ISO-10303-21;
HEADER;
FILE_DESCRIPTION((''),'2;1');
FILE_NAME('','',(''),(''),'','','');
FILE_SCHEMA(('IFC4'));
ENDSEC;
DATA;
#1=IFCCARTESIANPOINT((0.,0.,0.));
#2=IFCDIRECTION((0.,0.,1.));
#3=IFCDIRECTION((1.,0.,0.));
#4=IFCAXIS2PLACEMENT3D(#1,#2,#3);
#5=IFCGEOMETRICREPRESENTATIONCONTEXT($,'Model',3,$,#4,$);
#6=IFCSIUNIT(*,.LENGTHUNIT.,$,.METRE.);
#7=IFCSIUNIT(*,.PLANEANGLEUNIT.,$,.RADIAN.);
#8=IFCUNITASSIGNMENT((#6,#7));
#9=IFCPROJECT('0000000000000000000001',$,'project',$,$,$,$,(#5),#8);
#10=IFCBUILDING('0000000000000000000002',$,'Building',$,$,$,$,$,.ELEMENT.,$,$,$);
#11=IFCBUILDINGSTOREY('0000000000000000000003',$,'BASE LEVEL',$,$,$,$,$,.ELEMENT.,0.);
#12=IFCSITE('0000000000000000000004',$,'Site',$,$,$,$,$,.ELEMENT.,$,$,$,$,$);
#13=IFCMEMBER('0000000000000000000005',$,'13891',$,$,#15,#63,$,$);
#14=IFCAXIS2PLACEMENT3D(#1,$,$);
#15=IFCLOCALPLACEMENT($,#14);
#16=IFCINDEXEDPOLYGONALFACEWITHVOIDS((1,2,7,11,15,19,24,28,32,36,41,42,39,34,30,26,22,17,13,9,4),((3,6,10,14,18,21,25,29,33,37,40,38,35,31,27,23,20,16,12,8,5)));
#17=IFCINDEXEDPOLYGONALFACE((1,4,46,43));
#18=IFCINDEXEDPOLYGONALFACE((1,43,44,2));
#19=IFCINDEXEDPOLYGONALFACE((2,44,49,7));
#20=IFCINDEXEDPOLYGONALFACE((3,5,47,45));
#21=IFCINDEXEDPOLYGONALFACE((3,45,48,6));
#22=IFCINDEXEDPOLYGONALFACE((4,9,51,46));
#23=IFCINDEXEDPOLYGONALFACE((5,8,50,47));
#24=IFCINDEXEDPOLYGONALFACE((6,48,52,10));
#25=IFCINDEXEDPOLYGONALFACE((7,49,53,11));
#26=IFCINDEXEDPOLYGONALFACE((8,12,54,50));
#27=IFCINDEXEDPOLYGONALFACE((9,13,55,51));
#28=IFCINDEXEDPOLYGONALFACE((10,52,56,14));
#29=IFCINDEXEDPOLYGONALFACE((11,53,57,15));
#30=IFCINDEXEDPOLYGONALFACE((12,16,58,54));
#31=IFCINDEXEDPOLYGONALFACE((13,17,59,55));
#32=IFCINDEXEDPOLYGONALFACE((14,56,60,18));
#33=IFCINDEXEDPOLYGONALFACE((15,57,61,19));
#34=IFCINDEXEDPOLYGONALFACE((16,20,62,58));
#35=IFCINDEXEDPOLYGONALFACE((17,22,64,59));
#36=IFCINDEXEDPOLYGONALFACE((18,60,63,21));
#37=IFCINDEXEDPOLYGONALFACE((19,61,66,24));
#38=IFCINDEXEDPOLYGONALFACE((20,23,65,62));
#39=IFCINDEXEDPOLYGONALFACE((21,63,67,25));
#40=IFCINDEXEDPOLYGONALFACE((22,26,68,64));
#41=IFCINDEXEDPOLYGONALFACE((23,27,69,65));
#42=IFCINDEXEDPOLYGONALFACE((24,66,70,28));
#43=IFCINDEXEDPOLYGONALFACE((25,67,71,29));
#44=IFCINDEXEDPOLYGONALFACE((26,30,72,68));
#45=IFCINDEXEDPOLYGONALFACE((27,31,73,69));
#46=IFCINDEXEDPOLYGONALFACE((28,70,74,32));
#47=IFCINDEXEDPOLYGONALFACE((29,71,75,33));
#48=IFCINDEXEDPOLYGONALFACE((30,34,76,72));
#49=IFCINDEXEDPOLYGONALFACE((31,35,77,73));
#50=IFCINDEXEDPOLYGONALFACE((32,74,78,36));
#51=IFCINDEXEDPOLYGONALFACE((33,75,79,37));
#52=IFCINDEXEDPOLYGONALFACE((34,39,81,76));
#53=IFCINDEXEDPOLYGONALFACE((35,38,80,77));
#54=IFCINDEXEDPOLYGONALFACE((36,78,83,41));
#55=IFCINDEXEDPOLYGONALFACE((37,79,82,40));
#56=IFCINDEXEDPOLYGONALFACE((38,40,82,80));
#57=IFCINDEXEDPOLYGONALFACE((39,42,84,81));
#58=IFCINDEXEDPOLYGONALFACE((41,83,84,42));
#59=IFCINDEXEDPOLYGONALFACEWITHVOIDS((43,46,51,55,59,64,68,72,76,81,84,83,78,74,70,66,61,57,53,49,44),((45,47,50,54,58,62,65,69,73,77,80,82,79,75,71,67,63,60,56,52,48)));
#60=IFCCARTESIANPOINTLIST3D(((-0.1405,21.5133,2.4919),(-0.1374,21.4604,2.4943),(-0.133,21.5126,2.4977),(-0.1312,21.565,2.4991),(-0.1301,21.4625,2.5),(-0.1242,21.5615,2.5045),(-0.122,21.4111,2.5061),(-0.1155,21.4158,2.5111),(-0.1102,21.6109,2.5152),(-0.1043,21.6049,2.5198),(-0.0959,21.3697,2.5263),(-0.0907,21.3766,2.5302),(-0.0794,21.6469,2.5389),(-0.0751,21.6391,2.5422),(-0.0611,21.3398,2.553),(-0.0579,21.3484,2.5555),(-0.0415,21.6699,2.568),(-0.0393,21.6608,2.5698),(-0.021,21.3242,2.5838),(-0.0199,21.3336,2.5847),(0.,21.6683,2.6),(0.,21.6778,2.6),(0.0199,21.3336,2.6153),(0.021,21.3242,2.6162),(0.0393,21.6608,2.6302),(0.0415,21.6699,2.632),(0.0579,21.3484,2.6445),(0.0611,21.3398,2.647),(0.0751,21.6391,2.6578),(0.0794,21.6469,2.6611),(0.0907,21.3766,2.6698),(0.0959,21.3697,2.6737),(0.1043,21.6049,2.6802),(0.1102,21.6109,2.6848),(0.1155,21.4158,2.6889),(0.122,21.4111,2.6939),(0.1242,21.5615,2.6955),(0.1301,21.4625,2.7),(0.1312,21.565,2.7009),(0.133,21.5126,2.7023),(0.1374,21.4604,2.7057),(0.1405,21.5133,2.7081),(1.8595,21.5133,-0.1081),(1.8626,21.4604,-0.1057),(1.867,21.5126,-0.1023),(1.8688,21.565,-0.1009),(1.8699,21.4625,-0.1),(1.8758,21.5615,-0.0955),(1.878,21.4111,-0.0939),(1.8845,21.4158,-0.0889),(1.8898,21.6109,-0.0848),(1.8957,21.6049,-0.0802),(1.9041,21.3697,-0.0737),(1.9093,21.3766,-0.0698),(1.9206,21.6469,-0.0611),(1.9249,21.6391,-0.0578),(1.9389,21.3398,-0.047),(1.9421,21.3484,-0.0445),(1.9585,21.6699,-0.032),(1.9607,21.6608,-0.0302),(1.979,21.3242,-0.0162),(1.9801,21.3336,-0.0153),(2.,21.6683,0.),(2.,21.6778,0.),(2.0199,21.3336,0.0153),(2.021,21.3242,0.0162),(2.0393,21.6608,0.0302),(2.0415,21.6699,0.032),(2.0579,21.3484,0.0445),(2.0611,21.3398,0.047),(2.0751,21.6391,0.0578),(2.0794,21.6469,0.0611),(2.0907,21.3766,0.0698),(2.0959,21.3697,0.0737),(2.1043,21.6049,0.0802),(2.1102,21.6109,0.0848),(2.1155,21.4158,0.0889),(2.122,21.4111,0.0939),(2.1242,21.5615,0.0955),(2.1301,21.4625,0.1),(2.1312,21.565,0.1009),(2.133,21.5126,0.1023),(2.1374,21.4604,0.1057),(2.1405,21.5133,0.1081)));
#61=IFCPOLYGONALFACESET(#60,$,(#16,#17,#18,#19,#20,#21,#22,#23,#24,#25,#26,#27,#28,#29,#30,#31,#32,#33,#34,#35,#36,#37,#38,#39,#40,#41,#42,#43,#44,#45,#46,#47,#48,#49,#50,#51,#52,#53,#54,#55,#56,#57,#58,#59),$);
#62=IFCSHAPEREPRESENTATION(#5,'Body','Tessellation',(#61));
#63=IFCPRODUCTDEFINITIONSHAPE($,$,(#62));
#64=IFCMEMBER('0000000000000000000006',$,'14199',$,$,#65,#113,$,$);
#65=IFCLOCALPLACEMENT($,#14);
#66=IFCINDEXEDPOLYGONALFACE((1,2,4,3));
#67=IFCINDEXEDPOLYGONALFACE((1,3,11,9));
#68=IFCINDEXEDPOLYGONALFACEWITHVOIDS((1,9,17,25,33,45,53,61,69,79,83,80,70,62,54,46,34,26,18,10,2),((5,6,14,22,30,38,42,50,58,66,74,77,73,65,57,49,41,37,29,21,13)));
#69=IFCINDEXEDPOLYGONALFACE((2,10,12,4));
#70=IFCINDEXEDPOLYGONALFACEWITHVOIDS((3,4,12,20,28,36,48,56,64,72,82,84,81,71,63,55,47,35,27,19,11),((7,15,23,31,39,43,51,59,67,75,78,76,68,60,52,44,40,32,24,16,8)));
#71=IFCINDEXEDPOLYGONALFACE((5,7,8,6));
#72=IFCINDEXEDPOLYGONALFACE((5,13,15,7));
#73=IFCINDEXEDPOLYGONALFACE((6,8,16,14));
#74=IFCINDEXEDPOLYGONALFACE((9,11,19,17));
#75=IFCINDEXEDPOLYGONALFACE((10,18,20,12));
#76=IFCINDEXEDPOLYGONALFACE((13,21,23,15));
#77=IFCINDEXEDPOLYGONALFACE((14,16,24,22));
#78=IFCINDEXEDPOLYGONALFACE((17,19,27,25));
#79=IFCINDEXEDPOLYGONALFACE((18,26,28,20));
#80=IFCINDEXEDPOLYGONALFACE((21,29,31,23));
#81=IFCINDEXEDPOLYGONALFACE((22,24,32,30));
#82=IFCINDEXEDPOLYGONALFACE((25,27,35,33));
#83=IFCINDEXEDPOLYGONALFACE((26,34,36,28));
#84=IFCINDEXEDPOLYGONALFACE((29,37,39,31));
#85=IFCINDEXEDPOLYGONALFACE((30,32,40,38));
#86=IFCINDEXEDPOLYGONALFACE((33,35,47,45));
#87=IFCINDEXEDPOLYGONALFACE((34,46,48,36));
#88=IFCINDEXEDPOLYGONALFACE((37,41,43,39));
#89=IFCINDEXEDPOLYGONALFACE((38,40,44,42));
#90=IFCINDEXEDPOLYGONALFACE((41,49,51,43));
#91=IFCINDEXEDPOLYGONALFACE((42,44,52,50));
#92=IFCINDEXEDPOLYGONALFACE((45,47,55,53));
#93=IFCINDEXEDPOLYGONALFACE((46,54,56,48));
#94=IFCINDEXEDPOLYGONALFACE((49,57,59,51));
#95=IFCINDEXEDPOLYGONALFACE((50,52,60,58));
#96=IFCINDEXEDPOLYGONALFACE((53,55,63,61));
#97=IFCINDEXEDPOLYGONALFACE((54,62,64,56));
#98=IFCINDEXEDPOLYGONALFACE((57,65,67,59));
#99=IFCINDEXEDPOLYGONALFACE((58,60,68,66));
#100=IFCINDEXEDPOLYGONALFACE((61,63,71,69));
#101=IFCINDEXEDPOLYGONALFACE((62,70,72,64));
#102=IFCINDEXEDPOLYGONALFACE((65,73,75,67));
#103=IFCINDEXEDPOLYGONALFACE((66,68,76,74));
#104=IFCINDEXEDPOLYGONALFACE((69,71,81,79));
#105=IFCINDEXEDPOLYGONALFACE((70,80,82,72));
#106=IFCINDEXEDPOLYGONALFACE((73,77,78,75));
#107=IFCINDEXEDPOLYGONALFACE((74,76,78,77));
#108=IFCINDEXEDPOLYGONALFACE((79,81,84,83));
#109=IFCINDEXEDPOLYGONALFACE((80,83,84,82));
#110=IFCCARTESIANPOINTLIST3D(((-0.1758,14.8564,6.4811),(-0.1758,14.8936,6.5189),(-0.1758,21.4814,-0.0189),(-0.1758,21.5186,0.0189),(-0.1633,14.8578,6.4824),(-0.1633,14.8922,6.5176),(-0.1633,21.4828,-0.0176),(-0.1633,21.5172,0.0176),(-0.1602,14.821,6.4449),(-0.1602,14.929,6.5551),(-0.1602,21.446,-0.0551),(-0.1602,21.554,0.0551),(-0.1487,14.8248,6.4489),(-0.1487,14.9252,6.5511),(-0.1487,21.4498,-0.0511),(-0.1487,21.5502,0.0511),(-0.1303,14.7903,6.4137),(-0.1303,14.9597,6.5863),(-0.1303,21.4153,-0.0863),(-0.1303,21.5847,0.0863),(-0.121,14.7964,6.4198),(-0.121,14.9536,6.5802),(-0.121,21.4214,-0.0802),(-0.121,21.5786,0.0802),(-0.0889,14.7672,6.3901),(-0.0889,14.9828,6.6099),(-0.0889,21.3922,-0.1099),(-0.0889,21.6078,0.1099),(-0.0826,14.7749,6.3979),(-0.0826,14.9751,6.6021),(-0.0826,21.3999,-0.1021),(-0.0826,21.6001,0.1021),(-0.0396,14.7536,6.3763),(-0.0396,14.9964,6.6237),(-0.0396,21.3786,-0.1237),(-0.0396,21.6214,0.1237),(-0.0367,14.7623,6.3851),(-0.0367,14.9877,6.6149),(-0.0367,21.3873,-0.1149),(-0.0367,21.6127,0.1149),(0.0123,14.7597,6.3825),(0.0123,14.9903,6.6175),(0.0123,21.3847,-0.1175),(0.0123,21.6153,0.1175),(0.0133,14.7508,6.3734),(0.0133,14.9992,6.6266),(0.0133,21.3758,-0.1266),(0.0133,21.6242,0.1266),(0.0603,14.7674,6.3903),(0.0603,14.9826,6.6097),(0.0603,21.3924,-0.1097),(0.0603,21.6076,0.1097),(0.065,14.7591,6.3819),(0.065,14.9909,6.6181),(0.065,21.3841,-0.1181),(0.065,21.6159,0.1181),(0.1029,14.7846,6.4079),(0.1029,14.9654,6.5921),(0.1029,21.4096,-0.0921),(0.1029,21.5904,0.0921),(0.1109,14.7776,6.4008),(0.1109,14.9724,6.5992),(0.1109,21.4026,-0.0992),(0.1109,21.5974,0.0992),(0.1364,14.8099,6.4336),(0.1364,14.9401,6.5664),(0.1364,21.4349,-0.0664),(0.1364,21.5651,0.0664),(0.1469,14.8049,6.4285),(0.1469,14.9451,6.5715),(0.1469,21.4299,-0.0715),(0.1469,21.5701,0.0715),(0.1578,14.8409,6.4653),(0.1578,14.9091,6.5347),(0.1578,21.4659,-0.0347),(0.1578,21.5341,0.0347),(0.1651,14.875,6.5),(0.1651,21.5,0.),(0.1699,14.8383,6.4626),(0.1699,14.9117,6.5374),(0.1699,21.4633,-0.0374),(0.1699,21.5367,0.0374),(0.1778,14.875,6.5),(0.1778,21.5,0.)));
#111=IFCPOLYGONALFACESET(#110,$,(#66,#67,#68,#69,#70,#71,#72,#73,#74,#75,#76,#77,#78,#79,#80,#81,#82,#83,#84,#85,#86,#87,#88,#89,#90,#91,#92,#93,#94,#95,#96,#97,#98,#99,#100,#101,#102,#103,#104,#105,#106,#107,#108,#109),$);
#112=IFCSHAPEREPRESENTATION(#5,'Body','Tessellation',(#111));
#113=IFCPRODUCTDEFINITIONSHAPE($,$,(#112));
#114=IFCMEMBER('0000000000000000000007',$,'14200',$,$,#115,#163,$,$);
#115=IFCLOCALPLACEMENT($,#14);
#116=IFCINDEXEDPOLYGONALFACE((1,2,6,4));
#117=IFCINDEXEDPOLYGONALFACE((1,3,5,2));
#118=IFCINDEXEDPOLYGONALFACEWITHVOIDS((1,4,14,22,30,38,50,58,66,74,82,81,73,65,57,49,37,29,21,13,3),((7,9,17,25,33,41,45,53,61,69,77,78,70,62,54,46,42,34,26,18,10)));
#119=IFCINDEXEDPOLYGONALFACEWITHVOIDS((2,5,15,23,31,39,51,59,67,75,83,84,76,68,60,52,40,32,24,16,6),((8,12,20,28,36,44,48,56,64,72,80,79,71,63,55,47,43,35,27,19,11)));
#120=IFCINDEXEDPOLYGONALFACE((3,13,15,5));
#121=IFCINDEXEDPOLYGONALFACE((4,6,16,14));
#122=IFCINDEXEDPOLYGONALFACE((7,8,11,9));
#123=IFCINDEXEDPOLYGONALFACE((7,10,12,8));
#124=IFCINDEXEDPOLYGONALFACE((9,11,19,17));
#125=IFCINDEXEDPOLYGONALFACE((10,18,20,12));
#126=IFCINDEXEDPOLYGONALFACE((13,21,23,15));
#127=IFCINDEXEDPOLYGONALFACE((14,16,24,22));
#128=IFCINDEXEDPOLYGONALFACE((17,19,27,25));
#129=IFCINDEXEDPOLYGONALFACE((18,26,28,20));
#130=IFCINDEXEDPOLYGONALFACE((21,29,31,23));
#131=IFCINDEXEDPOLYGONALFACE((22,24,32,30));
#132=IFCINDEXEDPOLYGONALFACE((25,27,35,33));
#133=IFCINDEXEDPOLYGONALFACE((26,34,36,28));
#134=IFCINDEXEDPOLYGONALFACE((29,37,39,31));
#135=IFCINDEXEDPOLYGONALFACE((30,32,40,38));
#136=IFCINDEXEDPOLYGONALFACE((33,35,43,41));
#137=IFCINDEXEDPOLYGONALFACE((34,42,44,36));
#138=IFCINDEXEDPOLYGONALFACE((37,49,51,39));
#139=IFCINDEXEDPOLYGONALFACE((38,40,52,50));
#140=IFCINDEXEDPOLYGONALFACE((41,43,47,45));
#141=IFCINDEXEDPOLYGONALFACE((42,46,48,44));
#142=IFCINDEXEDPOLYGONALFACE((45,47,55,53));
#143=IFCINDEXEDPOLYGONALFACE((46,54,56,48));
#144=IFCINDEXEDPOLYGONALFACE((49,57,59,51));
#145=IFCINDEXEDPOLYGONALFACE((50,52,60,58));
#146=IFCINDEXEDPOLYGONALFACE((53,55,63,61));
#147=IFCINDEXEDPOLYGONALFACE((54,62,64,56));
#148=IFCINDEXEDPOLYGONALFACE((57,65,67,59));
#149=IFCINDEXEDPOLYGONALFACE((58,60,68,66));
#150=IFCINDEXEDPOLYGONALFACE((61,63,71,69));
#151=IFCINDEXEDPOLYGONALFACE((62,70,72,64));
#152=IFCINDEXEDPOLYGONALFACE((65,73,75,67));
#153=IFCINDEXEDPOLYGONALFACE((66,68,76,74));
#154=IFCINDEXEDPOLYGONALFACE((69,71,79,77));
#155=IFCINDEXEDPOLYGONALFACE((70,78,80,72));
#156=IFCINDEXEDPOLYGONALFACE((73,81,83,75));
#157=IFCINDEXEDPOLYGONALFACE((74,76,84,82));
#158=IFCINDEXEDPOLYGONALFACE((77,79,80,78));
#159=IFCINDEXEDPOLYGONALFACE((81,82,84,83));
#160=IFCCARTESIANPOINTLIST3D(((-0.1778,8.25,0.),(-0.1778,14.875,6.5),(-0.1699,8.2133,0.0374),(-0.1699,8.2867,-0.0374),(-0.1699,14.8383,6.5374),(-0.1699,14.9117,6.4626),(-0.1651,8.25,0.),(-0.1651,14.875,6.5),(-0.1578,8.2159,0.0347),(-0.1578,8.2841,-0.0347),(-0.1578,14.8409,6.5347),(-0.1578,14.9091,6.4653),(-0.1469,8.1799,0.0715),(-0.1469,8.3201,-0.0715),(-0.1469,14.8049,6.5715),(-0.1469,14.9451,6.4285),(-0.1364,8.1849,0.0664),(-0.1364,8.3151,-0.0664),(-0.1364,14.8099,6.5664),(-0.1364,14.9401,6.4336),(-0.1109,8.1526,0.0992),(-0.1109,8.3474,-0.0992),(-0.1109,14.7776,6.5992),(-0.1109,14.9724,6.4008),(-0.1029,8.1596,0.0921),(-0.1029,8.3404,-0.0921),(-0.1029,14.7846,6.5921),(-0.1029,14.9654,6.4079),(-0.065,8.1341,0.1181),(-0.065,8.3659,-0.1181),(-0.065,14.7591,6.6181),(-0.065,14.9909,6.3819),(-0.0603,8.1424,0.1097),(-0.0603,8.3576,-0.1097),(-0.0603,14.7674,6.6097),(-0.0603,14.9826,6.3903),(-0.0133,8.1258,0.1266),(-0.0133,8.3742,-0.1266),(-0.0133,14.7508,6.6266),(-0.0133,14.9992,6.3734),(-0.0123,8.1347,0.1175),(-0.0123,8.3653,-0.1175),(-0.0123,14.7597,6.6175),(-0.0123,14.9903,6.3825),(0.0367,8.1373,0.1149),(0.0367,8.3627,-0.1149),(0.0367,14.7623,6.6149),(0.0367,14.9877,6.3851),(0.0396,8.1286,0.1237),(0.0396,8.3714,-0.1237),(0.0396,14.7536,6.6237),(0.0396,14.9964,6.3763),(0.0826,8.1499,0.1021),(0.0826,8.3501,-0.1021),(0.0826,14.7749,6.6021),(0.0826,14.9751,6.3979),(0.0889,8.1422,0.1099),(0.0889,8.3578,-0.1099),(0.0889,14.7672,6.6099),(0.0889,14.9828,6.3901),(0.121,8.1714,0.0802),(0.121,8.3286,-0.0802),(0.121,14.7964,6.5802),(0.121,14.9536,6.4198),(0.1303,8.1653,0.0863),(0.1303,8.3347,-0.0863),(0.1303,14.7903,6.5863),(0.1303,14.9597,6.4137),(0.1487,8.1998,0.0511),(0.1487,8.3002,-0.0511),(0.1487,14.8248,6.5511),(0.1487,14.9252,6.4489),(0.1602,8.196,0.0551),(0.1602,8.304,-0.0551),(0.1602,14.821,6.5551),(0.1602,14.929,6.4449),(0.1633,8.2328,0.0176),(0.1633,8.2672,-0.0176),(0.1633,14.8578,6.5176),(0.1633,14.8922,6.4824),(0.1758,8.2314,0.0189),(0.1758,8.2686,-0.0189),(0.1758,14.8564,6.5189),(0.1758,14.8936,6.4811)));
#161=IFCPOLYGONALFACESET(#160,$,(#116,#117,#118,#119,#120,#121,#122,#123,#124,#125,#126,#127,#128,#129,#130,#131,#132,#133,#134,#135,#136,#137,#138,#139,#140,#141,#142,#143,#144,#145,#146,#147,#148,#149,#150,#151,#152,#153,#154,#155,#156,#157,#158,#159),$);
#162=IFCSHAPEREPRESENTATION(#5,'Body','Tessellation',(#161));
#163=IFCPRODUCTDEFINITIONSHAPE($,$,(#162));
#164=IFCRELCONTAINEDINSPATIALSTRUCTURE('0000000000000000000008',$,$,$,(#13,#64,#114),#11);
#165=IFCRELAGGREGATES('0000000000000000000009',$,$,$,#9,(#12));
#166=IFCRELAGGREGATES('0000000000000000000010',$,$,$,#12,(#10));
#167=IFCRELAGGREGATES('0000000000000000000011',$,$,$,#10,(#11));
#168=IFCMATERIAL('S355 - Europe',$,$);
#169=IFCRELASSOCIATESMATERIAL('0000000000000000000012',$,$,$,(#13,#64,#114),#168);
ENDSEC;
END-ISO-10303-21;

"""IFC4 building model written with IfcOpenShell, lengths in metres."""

from ifc_helpers import new_model, si_unit, frame, origin_with_axes, origin_2d_with_axis, place, context, project, spatial, hollow_circle, extrude, material, material_profile, profile_set, profile_usage, element, save


model = new_model("IFC4")

# Units and contexts
model_context = context("Model", 3, world=origin_with_axes())
ifc_project = project(units=[si_unit("LENGTHUNIT", "METRE"), si_unit("PLANEANGLEUNIT", "RADIAN")], contexts=[model_context])

# Site, building, storey
site = spatial("IfcSite", under=ifc_project, Name="Site", CompositionType="ELEMENT")
building = spatial("IfcBuilding", under=site, Name="Building", CompositionType="ELEMENT")
storey = spatial("IfcBuildingStorey", under=building, Name="BASE LEVEL", CompositionType="ELEMENT", Elevation=0.0)

# Shared definitions
ifc_material = material(Name="S355 - Europe")

# Members
ifc_material_profile_1 = material_profile(ifc_material, hollow_circle(Radius=0.1778, WallThickness=0.0095, at=origin_2d_with_axis()))
ifc_profile_set_1 = profile_set([ifc_material_profile_1])
ifc_profile_usage_1 = profile_usage(ifc_profile_set_1, cardinal=10)
member_1_placement = place(None, frame((0.0, 21.5, 2.6), z_axis=(0.609711, 0.0, -0.792624), x_axis=(0.0, 1.0, 0.0)))
element("IfcMember", 1, at=member_1_placement, inside=storey, material=ifc_profile_usage_1, Name="13891", context=model_context, shape_type="SweptSolid", body=[
    extrude(hollow_circle(Radius=0.1778, WallThickness=0.0095, at=origin_2d_with_axis()), origin_with_axes(), (0.0, 0.0, 1.0), 3.2802),
])
ifc_material_profile_2 = material_profile(ifc_material, hollow_circle(Radius=0.1778, WallThickness=0.0127, at=origin_2d_with_axis()))
ifc_profile_set_2 = profile_set([ifc_material_profile_2])
ifc_profile_usage_2 = profile_usage(ifc_profile_set_2, cardinal=10)
member_2_placement = place(None, frame((0.0, 21.5, 0.0), z_axis=(0.0, -0.713809, 0.700341), x_axis=(1.0, 0.0, 0.0)))
element("IfcMember", 2, at=member_2_placement, inside=storey, material=ifc_profile_usage_2, Name="14199", context=model_context, shape_type="SweptSolid", body=[
    extrude(hollow_circle(Radius=0.1778, WallThickness=0.0127, at=origin_2d_with_axis()), origin_with_axes(), (0.0, 0.0, 1.0), 9.2812),
])
ifc_material_profile_3 = material_profile(ifc_material, hollow_circle(Radius=0.1778, WallThickness=0.0127, at=origin_2d_with_axis()))
ifc_profile_set_3 = profile_set([ifc_material_profile_3])
ifc_profile_usage_3 = profile_usage(ifc_profile_set_3, cardinal=10)
member_3_placement = place(None, frame((0.0, 8.25, 0.0), z_axis=(0.0, 0.713809, 0.700341), x_axis=(-1.0, 0.0, 0.0)))
element("IfcMember", 3, at=member_3_placement, inside=storey, material=ifc_profile_usage_3, Name="14200", context=model_context, shape_type="SweptSolid", body=[
    extrude(hollow_circle(Radius=0.1778, WallThickness=0.0127, at=origin_2d_with_axis()), origin_with_axes(), (0.0, 0.0, 1.0), 9.2812),
])

save(model, "model.ifc")
